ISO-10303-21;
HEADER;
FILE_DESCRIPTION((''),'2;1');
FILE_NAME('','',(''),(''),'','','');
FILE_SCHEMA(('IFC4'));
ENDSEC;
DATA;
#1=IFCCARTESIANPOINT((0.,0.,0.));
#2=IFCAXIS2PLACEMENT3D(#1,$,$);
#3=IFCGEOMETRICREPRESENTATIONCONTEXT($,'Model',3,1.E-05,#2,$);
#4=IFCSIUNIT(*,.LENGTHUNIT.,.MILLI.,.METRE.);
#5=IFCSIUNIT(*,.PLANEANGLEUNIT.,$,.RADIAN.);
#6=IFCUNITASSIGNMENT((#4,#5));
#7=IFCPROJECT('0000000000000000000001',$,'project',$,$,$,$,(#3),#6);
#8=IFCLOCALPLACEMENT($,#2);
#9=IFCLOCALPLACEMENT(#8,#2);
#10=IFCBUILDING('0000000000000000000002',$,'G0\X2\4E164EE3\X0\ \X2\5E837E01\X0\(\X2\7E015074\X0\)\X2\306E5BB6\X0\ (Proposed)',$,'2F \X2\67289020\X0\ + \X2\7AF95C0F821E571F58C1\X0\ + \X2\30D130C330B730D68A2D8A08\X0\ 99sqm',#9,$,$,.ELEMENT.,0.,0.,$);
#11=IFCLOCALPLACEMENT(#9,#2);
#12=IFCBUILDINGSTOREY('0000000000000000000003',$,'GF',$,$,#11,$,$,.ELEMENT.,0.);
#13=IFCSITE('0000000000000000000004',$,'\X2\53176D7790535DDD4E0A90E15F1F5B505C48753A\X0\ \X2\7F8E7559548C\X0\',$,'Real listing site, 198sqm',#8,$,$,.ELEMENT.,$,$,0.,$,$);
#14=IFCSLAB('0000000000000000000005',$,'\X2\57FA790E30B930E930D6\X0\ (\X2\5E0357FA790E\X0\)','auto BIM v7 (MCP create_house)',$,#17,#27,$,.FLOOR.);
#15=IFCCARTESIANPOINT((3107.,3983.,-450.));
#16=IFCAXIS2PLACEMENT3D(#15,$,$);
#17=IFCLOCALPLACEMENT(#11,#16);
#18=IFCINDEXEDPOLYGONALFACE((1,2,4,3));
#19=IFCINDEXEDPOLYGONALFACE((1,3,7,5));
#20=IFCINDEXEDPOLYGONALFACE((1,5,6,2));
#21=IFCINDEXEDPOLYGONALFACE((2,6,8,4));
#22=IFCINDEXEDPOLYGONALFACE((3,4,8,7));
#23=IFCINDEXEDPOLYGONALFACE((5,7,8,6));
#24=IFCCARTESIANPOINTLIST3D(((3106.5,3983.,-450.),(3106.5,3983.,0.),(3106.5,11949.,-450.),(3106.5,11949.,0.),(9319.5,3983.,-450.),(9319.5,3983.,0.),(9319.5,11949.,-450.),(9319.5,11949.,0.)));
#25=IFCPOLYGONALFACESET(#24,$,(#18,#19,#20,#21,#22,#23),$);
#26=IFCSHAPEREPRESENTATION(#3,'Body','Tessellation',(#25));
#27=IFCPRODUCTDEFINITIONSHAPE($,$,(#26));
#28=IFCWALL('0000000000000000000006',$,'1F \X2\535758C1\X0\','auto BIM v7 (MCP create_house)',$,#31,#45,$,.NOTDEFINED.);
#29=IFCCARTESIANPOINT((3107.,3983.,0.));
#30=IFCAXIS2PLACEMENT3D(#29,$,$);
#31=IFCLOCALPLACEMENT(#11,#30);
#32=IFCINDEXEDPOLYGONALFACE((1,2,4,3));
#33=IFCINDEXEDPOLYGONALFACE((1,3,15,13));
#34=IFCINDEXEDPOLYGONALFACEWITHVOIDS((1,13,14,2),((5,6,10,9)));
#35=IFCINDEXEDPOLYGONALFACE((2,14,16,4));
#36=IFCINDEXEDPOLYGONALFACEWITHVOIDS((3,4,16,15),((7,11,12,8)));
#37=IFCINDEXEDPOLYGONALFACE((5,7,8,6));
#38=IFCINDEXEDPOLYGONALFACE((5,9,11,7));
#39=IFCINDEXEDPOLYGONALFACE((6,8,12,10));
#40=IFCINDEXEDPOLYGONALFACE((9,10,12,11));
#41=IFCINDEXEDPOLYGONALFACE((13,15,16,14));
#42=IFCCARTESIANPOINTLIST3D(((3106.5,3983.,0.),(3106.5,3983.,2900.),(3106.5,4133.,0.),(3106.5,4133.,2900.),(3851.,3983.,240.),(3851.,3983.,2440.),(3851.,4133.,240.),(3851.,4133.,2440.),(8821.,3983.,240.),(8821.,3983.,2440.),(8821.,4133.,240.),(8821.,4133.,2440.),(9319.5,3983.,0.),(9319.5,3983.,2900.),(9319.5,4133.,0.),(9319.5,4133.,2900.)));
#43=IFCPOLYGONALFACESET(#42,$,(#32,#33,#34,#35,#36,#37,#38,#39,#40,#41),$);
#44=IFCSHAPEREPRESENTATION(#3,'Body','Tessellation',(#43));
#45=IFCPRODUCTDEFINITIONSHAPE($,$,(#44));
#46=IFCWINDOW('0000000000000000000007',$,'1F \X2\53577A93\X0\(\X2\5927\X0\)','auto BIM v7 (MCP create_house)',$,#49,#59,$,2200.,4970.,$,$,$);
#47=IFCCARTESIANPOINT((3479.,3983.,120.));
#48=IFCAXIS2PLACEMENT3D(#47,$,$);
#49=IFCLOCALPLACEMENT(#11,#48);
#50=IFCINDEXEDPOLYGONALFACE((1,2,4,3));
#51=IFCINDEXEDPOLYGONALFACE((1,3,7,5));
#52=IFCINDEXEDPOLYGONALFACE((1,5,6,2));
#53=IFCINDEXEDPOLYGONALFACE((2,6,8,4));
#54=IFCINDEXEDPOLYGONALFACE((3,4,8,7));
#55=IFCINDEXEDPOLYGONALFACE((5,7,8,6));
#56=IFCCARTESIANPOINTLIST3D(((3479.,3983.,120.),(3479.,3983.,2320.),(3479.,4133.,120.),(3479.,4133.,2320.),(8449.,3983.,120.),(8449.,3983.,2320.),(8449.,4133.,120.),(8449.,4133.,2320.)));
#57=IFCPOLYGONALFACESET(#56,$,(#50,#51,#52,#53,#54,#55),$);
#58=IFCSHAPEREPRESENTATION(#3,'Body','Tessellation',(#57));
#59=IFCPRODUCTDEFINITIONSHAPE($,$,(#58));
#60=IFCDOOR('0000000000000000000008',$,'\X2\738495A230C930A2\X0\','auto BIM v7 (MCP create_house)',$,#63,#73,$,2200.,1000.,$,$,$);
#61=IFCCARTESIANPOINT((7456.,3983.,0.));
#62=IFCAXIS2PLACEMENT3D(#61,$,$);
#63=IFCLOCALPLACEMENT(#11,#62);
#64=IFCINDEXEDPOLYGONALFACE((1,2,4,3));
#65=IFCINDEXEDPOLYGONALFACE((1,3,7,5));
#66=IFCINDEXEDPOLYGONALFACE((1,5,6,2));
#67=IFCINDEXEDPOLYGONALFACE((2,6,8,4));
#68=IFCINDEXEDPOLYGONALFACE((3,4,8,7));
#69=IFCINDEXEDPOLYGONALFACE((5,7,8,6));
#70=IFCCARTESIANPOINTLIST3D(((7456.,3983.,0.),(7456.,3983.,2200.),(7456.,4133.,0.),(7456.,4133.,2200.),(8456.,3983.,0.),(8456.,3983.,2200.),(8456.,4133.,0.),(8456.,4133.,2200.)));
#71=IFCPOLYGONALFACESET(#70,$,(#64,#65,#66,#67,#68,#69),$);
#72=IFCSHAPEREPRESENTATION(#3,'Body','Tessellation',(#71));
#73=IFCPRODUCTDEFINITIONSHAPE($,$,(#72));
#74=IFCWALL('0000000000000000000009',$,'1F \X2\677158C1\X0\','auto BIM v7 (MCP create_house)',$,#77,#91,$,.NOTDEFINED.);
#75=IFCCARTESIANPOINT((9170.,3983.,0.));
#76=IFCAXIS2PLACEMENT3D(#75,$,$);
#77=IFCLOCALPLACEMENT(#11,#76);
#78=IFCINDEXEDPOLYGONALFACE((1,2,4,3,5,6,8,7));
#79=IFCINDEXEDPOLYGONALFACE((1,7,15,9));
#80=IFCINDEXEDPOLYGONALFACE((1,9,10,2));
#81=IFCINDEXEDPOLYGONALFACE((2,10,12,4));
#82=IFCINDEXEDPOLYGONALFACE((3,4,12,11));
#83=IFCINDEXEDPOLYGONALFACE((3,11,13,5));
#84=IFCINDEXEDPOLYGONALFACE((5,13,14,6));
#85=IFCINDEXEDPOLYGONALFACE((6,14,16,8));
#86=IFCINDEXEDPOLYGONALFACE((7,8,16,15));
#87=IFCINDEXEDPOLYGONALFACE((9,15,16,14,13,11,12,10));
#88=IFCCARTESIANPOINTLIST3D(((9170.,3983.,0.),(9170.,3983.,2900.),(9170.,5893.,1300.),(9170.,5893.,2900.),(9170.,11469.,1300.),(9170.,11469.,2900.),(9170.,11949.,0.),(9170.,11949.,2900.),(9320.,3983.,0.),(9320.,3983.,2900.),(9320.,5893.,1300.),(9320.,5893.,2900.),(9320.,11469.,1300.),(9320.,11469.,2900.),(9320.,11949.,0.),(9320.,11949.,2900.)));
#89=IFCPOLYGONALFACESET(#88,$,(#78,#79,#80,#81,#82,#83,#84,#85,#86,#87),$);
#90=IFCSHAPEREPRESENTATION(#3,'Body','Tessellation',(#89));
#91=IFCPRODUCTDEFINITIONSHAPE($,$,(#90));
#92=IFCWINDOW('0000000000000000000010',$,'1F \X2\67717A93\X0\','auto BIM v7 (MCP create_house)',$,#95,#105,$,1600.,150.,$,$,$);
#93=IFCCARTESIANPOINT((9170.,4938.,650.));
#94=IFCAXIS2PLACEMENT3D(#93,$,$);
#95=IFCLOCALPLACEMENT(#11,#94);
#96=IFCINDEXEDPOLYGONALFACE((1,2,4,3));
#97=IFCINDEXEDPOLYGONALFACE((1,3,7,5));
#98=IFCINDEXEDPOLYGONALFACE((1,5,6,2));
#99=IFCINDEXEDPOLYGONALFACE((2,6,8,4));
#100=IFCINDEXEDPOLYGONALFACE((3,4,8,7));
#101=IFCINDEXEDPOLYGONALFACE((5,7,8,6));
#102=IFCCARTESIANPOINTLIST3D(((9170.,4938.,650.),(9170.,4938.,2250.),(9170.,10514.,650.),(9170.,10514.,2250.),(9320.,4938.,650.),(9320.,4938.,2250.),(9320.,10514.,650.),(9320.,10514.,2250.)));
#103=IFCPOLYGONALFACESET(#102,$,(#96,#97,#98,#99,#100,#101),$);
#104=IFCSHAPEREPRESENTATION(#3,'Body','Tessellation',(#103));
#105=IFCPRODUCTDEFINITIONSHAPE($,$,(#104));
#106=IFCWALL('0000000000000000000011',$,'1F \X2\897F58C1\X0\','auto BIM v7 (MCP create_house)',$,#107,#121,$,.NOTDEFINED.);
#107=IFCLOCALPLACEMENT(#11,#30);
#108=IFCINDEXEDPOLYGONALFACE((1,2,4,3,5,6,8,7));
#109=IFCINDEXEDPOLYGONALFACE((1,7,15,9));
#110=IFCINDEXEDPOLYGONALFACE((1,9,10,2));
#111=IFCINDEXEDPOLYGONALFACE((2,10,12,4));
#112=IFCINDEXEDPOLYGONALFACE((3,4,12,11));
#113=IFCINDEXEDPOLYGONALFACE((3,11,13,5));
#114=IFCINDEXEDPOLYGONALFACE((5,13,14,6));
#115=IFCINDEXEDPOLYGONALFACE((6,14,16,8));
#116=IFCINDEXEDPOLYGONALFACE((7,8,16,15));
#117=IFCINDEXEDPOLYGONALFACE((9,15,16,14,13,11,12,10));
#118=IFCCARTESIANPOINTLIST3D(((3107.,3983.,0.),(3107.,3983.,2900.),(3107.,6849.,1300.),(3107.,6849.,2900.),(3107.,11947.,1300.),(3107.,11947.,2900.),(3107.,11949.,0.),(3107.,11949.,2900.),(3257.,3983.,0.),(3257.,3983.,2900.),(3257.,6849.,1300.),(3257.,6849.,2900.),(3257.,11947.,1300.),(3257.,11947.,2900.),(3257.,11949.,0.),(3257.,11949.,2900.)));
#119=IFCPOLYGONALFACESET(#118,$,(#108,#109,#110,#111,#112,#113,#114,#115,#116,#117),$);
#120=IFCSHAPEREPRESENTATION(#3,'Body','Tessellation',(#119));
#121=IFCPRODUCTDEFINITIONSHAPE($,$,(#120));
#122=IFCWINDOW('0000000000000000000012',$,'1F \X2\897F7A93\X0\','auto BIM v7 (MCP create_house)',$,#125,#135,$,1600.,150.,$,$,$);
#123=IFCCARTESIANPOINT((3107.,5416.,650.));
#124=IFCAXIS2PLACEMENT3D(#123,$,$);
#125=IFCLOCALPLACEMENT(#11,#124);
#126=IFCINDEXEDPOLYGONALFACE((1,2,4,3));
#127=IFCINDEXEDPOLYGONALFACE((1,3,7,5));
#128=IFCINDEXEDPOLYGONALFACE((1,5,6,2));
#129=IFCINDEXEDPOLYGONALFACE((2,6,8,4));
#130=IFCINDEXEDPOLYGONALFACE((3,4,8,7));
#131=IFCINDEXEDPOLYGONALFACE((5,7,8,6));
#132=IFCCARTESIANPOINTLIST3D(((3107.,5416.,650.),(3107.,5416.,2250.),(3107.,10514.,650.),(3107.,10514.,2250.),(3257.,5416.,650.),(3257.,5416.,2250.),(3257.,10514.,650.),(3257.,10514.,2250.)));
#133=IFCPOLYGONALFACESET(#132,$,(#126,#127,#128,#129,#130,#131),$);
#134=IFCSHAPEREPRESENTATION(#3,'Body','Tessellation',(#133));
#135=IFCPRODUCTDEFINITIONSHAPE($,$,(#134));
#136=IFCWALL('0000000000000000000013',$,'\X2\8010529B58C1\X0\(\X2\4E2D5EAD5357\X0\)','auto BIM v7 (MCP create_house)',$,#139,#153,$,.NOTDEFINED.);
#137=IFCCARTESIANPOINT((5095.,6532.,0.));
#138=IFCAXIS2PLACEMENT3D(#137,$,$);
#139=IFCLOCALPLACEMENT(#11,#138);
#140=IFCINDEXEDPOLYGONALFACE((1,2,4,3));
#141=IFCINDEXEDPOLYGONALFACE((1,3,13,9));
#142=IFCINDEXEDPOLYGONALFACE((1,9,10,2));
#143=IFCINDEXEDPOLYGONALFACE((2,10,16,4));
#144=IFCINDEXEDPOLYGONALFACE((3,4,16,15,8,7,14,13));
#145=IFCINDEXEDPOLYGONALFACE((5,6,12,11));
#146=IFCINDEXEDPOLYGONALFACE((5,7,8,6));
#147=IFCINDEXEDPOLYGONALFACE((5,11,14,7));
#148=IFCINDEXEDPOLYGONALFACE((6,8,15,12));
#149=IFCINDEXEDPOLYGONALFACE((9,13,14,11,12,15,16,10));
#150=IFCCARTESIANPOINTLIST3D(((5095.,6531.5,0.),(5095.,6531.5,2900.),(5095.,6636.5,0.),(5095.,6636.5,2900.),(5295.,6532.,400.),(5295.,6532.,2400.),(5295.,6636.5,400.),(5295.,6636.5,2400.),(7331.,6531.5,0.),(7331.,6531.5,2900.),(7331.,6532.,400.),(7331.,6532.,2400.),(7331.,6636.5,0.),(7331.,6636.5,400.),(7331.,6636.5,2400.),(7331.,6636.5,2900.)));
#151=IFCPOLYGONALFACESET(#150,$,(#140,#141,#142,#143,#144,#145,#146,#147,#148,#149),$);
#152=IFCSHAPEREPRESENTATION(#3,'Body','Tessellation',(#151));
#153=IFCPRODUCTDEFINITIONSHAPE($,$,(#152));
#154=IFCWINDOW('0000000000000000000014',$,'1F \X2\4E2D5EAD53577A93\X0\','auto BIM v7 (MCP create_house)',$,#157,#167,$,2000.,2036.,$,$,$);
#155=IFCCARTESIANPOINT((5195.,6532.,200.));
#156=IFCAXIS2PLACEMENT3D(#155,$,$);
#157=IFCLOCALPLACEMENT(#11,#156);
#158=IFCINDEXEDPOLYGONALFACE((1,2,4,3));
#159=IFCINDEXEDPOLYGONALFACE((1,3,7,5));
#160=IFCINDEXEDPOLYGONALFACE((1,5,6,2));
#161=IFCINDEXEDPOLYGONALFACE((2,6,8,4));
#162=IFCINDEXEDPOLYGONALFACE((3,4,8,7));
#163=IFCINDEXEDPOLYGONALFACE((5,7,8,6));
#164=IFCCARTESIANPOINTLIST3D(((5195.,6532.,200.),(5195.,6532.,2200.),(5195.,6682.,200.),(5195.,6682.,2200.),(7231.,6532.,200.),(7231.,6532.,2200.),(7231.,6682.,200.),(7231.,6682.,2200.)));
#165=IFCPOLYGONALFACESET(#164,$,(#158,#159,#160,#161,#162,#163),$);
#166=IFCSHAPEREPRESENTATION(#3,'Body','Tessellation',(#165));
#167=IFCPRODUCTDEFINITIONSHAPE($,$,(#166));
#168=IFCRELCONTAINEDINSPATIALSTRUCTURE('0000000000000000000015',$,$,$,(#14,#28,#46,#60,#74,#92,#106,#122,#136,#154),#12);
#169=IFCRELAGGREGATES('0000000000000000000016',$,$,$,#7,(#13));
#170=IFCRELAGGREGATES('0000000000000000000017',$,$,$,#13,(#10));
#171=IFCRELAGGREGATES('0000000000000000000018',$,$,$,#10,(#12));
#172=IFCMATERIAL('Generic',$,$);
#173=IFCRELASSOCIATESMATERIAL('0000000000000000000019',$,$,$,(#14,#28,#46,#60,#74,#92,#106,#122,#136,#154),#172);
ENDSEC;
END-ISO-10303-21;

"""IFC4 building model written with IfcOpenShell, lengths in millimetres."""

from ifc_helpers import new_model, si_unit, frame, frame_2d, origin, place, context, project, spatial, rectangle, extrude, material, element, fill, save


model = new_model("IFC4")

# Units and contexts
model_context = context("Model", 3, precision=1e-05, world=origin())
ifc_project = project(units=[si_unit("LENGTHUNIT", "METRE", prefix="MILLI"), si_unit("PLANEANGLEUNIT", "RADIAN")], contexts=[model_context])

# Site, building, storey
site_placement = place(None, origin())
site = spatial("IfcSite", under=ifc_project, at=site_placement, Name="北海道川上郡弟子屈町 美留和", ObjectType="Real listing site, 198sqm", CompositionType="ELEMENT", RefElevation=0.0)
building_placement = place(site_placement, origin())
building = spatial("IfcBuilding", under=site, at=building_placement, Name="G0世代 広縁(縁側)の家 (Proposed)", ObjectType="2F 木造 + 竹小舞土壁 + パッシブ設計 99sqm", CompositionType="ELEMENT", ElevationOfRefHeight=0.0, ElevationOfTerrain=0.0)
storey_placement = place(building_placement, origin())
storey = spatial("IfcBuildingStorey", under=building, at=storey_placement, Name="GF", CompositionType="ELEMENT", Elevation=0.0)

# Slab
ifc_material = material(Name="Generic")
slab_1_placement = place(storey_placement, frame((3107.0, 3983.0, -450.0)))
element("IfcSlab", 1, at=slab_1_placement, inside=storey, material=ifc_material, Name="基礎スラブ (布基礎)", Description="auto BIM v7 (MCP create_house)", PredefinedType="FLOOR", context=model_context, shape_type="SweptSolid", body=[
    extrude(rectangle(XDim=6213.0, YDim=7966.0, at=frame_2d((3106.0, 3983.0))), frame((3107.0, 3983.0, -450.0)), (0.0, 0.0, 1.0), 450.0),
])

# Wall, openings, window, door
wall_1_placement = place(storey_placement, frame((3107.0, 3983.0, 0.0)))
wall_1 = element("IfcWall", 2, at=wall_1_placement, inside=storey, material=ifc_material, Name="1F 南壁", Description="auto BIM v7 (MCP create_house)", PredefinedType="NOTDEFINED", context=model_context, shape_type="SweptSolid", body=[
    extrude(rectangle(XDim=6213.0, YDim=150.0, at=frame_2d((3106.0, 75.0))), frame((3107.0, 3983.0, 0.0)), (0.0, 0.0, 1.0), 2900.0),
])
opening_1_placement = place(storey_placement, frame((3479.0, 3983.0, 120.0)))
opening_1 = element("IfcOpeningElement", 3, at=opening_1_placement, cuts=wall_1, PredefinedType="NOTDEFINED", context=model_context, shape_type="SweptSolid", body=[
    extrude(rectangle(XDim=4970.0, YDim=150.0, at=frame_2d((2485.0, 75.0))), frame((3479.0, 3983.0, 120.0)), (0.0, 0.0, 1.0), 2200.0),
])
opening_2_placement = place(storey_placement, frame((7456.0, 3983.0, 0.0)))
opening_2 = element("IfcOpeningElement", 4, at=opening_2_placement, cuts=wall_1, PredefinedType="NOTDEFINED", context=model_context, shape_type="SweptSolid", body=[
    extrude(rectangle(XDim=1000.0, YDim=150.0, at=frame_2d((500.0, 75.0))), frame((7456.0, 3983.0, 0.0)), (0.0, 0.0, 1.0), 2200.0),
])
window_1_placement = place(storey_placement, frame((3479.0, 3983.0, 120.0)))
window_1 = element("IfcWindow", 5, at=window_1_placement, inside=storey, material=ifc_material, Name="1F 南窓(大)", Description="auto BIM v7 (MCP create_house)", OverallHeight=2200.0, OverallWidth=4970.0, context=model_context, shape_type="SweptSolid", body=[
    extrude(rectangle(XDim=4970.0, YDim=150.0, at=frame_2d((2485.0, 75.0))), frame((3479.0, 3983.0, 120.0)), (0.0, 0.0, 1.0), 2200.0),
])
fill(opening_1, window_1)
door_placement = place(storey_placement, frame((7456.0, 3983.0, 0.0)))
door = element("IfcDoor", 6, at=door_placement, inside=storey, material=ifc_material, Name="玄関ドア", Description="auto BIM v7 (MCP create_house)", OverallHeight=2200.0, OverallWidth=1000.0, context=model_context, shape_type="SweptSolid", body=[
    extrude(rectangle(XDim=1000.0, YDim=150.0, at=frame_2d((500.0, 75.0))), frame((7456.0, 3983.0, 0.0)), (0.0, 0.0, 1.0), 2200.0),
])
fill(opening_2, door)

# Walls, openings, windows
wall_2_placement = place(storey_placement, frame((9170.0, 3983.0, 0.0)))
wall_2 = element("IfcWall", 7, at=wall_2_placement, inside=storey, material=ifc_material, Name="1F 東壁", Description="auto BIM v7 (MCP create_house)", PredefinedType="NOTDEFINED", context=model_context, shape_type="SweptSolid", body=[
    extrude(rectangle(XDim=150.0, YDim=7966.0, at=frame_2d((75.0, 3983.0))), frame((9170.0, 3983.0, 0.0)), (0.0, 0.0, 1.0), 2900.0),
])
opening_3_placement = place(storey_placement, frame((9170.0, 4938.0, 650.0)))
opening_3 = element("IfcOpeningElement", 8, at=opening_3_placement, cuts=wall_2, PredefinedType="NOTDEFINED", context=model_context, shape_type="SweptSolid", body=[
    extrude(rectangle(XDim=150.0, YDim=5576.0, at=frame_2d((75.0, 2788.0))), frame((9170.0, 4938.0, 650.0)), (0.0, 0.0, 1.0), 1600.0),
])
window_2_placement = place(storey_placement, frame((9170.0, 4938.0, 650.0)))
window_2 = element("IfcWindow", 9, at=window_2_placement, inside=storey, material=ifc_material, Name="1F 東窓", Description="auto BIM v7 (MCP create_house)", OverallHeight=1600.0, OverallWidth=150.0, context=model_context, shape_type="SweptSolid", body=[
    extrude(rectangle(XDim=150.0, YDim=5576.0, at=frame_2d((75.0, 2788.0))), frame((9170.0, 4938.0, 650.0)), (0.0, 0.0, 1.0), 1600.0),
])
fill(opening_3, window_2)
wall_3_placement = place(storey_placement, frame((3107.0, 3983.0, 0.0)))
wall_3 = element("IfcWall", 10, at=wall_3_placement, inside=storey, material=ifc_material, Name="1F 西壁", Description="auto BIM v7 (MCP create_house)", PredefinedType="NOTDEFINED", context=model_context, shape_type="SweptSolid", body=[
    extrude(rectangle(XDim=150.0, YDim=7966.0, at=frame_2d((75.0, 3983.0))), frame((3107.0, 3983.0, 0.0)), (0.0, 0.0, 1.0), 2900.0),
])
opening_4_placement = place(storey_placement, frame((3107.0, 5416.0, 650.0)))
opening_4 = element("IfcOpeningElement", 11, at=opening_4_placement, cuts=wall_3, PredefinedType="NOTDEFINED", context=model_context, shape_type="SweptSolid", body=[
    extrude(rectangle(XDim=150.0, YDim=5098.0, at=frame_2d((75.0, 2549.0))), frame((3107.0, 5416.0, 650.0)), (0.0, 0.0, 1.0), 1600.0),
])
window_3_placement = place(storey_placement, frame((3107.0, 5416.0, 650.0)))
window_3 = element("IfcWindow", 12, at=window_3_placement, inside=storey, material=ifc_material, Name="1F 西窓", Description="auto BIM v7 (MCP create_house)", OverallHeight=1600.0, OverallWidth=150.0, context=model_context, shape_type="SweptSolid", body=[
    extrude(rectangle(XDim=150.0, YDim=5098.0, at=frame_2d((75.0, 2549.0))), frame((3107.0, 5416.0, 650.0)), (0.0, 0.0, 1.0), 1600.0),
])
fill(opening_4, window_3)
wall_4_placement = place(storey_placement, frame((5095.0, 6532.0, 0.0)))
wall_4 = element("IfcWall", 13, at=wall_4_placement, inside=storey, material=ifc_material, Name="耐力壁(中庭南)", Description="auto BIM v7 (MCP create_house)", PredefinedType="NOTDEFINED", context=model_context, shape_type="SweptSolid", body=[
    extrude(rectangle(XDim=2236.0, YDim=105.0, at=frame_2d((1118.0, 52.0))), frame((5095.0, 6532.0, 0.0)), (0.0, 0.0, 1.0), 2900.0),
])
opening_5_placement = place(storey_placement, frame((5195.0, 6532.0, 200.0)))
opening_5 = element("IfcOpeningElement", 14, at=opening_5_placement, cuts=wall_4, PredefinedType="NOTDEFINED", context=model_context, shape_type="SweptSolid", body=[
    extrude(rectangle(XDim=2036.0, YDim=150.0, at=frame_2d((1018.0, 75.0))), frame((5195.0, 6532.0, 200.0)), (0.0, 0.0, 1.0), 2000.0),
])
window_4_placement = place(storey_placement, frame((5195.0, 6532.0, 200.0)))
window_4 = element("IfcWindow", 15, at=window_4_placement, inside=storey, material=ifc_material, Name="1F 中庭南窓", Description="auto BIM v7 (MCP create_house)", OverallHeight=2000.0, OverallWidth=2036.0, context=model_context, shape_type="SweptSolid", body=[
    extrude(rectangle(XDim=2036.0, YDim=150.0, at=frame_2d((1018.0, 75.0))), frame((5195.0, 6532.0, 200.0)), (0.0, 0.0, 1.0), 2000.0),
])
fill(opening_5, window_4)

save(model, "model.ifc")
